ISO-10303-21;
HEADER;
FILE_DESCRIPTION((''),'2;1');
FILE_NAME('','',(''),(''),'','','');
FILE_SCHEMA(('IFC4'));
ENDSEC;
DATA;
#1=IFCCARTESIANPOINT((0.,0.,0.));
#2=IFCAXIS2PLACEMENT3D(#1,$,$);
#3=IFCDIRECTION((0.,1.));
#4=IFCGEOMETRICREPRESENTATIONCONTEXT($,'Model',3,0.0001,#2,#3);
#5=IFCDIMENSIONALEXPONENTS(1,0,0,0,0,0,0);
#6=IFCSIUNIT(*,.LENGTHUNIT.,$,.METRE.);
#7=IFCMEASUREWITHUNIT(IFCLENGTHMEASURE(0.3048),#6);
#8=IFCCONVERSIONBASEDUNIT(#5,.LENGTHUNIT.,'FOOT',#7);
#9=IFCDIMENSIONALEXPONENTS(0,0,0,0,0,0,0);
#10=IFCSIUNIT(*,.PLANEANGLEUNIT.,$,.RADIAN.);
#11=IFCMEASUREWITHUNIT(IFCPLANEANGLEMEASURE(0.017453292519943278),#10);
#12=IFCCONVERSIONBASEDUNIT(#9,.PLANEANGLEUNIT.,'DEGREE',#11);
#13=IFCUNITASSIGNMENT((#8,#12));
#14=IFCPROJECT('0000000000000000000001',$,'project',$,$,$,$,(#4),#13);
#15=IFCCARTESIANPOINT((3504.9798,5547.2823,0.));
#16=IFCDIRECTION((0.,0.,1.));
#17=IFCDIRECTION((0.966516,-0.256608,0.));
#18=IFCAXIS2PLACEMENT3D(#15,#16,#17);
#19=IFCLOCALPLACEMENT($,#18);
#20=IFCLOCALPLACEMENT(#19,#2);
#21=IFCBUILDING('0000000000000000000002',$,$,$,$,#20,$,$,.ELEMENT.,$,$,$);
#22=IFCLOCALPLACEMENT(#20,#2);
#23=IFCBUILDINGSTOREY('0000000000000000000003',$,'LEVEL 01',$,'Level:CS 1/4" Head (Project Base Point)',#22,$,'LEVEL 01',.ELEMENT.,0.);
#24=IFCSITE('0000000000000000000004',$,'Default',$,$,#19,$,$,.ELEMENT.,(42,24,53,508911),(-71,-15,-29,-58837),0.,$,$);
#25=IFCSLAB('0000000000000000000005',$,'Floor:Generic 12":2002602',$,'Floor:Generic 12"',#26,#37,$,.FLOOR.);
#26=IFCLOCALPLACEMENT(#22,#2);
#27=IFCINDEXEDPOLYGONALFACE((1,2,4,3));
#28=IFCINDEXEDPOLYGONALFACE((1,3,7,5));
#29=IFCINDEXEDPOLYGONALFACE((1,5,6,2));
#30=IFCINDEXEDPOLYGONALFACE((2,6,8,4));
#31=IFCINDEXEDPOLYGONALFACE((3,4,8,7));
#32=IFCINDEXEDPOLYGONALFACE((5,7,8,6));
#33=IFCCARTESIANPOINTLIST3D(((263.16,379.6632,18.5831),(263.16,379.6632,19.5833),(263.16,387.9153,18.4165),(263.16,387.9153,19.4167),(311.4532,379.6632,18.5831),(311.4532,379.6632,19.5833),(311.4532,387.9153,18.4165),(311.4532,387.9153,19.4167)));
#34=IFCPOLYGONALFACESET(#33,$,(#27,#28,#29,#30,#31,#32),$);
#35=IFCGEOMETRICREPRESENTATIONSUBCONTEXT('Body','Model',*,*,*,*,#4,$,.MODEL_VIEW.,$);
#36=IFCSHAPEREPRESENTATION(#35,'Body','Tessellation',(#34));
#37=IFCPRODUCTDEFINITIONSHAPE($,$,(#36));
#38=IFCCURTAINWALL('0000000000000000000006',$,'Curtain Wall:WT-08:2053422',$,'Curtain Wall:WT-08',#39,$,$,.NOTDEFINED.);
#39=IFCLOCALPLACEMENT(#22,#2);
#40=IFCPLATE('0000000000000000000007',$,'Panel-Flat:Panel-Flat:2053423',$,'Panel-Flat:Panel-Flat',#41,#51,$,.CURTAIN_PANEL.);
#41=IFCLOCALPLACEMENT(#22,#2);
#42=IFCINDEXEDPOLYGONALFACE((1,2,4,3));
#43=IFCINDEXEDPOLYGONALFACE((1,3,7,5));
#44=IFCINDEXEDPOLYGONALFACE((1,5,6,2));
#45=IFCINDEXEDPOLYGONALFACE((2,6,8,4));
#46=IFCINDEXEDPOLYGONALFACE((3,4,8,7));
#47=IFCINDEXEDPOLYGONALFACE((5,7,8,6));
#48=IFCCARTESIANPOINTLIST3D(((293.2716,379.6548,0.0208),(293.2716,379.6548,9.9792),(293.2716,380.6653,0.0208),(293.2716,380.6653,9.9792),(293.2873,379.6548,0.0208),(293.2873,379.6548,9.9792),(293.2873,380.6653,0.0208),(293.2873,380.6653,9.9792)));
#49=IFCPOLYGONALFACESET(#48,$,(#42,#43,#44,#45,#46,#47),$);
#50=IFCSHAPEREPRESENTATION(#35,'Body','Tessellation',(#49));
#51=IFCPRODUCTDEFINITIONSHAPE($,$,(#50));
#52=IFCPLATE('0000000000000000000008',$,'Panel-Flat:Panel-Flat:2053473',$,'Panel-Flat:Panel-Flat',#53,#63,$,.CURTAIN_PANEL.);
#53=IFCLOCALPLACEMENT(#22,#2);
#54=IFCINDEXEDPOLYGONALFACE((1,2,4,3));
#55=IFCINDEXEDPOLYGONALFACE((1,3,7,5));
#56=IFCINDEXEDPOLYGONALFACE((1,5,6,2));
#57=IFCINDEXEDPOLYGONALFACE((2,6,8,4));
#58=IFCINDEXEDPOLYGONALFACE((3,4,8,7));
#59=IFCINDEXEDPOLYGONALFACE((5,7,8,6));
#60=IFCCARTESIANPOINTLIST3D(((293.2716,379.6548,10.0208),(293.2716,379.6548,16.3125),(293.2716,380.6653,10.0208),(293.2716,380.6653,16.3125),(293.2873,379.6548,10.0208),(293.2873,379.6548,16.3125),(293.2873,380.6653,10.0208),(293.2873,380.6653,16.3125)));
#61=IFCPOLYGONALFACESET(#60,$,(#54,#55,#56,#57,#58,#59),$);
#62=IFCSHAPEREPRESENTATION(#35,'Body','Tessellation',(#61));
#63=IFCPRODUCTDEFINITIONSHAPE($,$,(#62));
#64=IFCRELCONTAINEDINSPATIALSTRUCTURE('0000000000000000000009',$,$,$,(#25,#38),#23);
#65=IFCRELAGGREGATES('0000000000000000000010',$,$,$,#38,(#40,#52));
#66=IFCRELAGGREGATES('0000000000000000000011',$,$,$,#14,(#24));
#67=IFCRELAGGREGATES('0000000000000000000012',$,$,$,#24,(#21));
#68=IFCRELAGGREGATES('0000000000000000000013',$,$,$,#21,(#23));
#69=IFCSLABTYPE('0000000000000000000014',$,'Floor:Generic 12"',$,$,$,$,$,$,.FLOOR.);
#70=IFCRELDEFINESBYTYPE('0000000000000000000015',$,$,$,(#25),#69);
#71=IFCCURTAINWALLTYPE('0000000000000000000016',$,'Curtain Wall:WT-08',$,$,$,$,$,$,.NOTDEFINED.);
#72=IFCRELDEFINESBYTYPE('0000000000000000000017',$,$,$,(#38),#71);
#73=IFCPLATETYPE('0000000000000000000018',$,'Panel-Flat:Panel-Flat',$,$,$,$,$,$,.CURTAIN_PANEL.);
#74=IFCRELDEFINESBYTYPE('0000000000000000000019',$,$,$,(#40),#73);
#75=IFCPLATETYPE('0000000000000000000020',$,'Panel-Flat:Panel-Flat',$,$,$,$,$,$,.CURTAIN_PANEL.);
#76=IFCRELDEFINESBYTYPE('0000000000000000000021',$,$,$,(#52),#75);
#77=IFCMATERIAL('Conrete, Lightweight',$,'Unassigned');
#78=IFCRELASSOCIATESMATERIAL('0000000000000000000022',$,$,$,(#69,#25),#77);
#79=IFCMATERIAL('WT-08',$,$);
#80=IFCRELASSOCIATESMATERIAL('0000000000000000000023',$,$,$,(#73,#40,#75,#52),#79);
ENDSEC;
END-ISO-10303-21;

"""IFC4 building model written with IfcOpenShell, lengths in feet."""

from ifc_helpers import new_model, entity, si_unit, converted_unit, direction, frame, frame_2d, origin, place, context, subcontext, project, spatial, indexed_curve, rectangle, outline, extrude, source, transform, mapped, material, type_object, type_shapes, element, aggregate, save


model = new_model("IFC4")

# Units and contexts
model_context = context("Model", 3, precision=0.0001, world=origin(), true_north=direction((0.0, 1.0)))
body_context = subcontext(model_context, "Body", "Model", "MODEL_VIEW")
ifc_project = project(units=[converted_unit("LENGTHUNIT", "FOOT", entity("IfcLengthMeasure", 0.3048), si_unit("LENGTHUNIT", "METRE"), dimensions=[1, 0, 0, 0, 0, 0, 0]), converted_unit("PLANEANGLEUNIT", "DEGREE", entity("IfcPlaneAngleMeasure", 0.017453292519943278), si_unit("PLANEANGLEUNIT", "RADIAN"), dimensions=[0, 0, 0, 0, 0, 0, 0])], contexts=[model_context])

# Site, building, storey
site_placement = place(None, frame((3504.9798, 5547.2823, 0.0), z_axis=(0.0, 0.0, 1.0), x_axis=(0.966516, -0.256608, 0.0)))
site = spatial("IfcSite", under=ifc_project, at=site_placement, Name="Default", CompositionType="ELEMENT", RefLatitude=(42, 24, 53, 508911), RefLongitude=(-71, -15, -29, -58837), RefElevation=0.0)
building_placement = place(site_placement, origin())
building = spatial("IfcBuilding", under=site, at=building_placement, CompositionType="ELEMENT")
storey_placement = place(building_placement, origin())
storey = spatial("IfcBuildingStorey", under=building, at=storey_placement, Name="LEVEL 01", ObjectType="Level:CS 1/4\" Head (Project Base Point)", LongName="LEVEL 01", CompositionType="ELEMENT", Elevation=0.0)

# Shared definitions
curtain_wall_type_1 = type_object("IfcCurtainWallType", Name="Curtain Wall:WT-08", PredefinedType="NOTDEFINED")
ifc_material_1 = material(Name="WT-08")

# Slab
ifc_material_2 = material(Name="Conrete, Lightweight", Category="Unassigned")
slab_type = type_object("IfcSlabType", Name="Floor:Generic 12\"", PredefinedType="FLOOR", material=ifc_material_2)
slab_placement = place(storey_placement, frame((263.16, 379.6632, 18.4165)))
element("IfcSlab", 1, at=slab_placement, inside=storey, type_object=slab_type, material=ifc_material_2, Name="Floor:Generic 12\":2002602", ObjectType="Floor:Generic 12\"", PredefinedType="FLOOR", context=body_context, shape_type="SweptSolid", body=[
    extrude(rectangle(XDim=48.2932, YDim=8.2537, at=frame_2d((0.0, 4.1269), x_axis=(-1.0, 0.0))), frame((24.1466, 0.0, 1.1669), z_axis=(0.0, 0.020193, 0.999796), x_axis=(1.0, 0.0, 0.0)), (0.0, 0.020193, -0.999796), 1.0002),
])

# Curtain wall, plates
curtain_wall_1_placement = place(storey_placement, origin())
curtain_wall_1 = element("IfcCurtainWall", 2, at=curtain_wall_1_placement, inside=storey, type_object=curtain_wall_type_1, Name="Curtain Wall:WT-08:2053422", ObjectType="Curtain Wall:WT-08", PredefinedType="NOTDEFINED")
plate_type_1 = type_object("IfcPlateType", Name="Panel-Flat:Panel-Flat", PredefinedType="CURTAIN_PANEL", material=ifc_material_1)
shared_shape_1 = source(origin(), body_context, "Body", "SweptSolid", [
    extrude(outline(indexed_curve([(-0.0078, -0.5052), (0.0078, -0.5052), (0.0078, 0.5052), (-0.0078, 0.5052), (-0.0078, -0.5052)], self_intersect=False)), frame((0.0, -0.0078, 0.0208), z_axis=(0.0, 0.0, 1.0), x_axis=(0.0, -1.0, 0.0)), (0.0, 0.0, 1.0), 9.9583),
])
type_shapes(plate_type_1, [shared_shape_1])
plate_1_placement = place(curtain_wall_1_placement, frame((293.2873, 380.1601, 0.0), z_axis=(0.0, 0.0, 1.0), x_axis=(0.0, -1.0, 0.0)))
plate_1 = element("IfcPlate", 3, at=plate_1_placement, type_object=plate_type_1, material=ifc_material_1, Name="Panel-Flat:Panel-Flat:2053423", ObjectType="Panel-Flat:Panel-Flat", PredefinedType="CURTAIN_PANEL", context=body_context, shape_type="MappedRepresentation", body=[
    mapped(shared_shape_1, transform((0.0, 0.0, 0.0), scale=1.0)),
])
plate_type_2 = type_object("IfcPlateType", Name="Panel-Flat:Panel-Flat", PredefinedType="CURTAIN_PANEL", material=ifc_material_1)
shared_shape_2 = source(origin(), body_context, "Body", "SweptSolid", [
    extrude(outline(indexed_curve([(-0.0078, -0.5052), (0.0078, -0.5052), (0.0078, 0.5052), (-0.0078, 0.5052), (-0.0078, -0.5052)], self_intersect=False)), frame((0.0, -0.0078, 0.0208), z_axis=(0.0, 0.0, 1.0), x_axis=(0.0, -1.0, 0.0)), (0.0, 0.0, 1.0), 6.2917),
])
type_shapes(plate_type_2, [shared_shape_2])
plate_2_placement = place(curtain_wall_1_placement, frame((293.2873, 380.1601, 10.0), z_axis=(0.0, 0.0, 1.0), x_axis=(0.0, -1.0, 0.0)))
plate_2 = element("IfcPlate", 4, at=plate_2_placement, type_object=plate_type_2, material=ifc_material_1, Name="Panel-Flat:Panel-Flat:2053473", ObjectType="Panel-Flat:Panel-Flat", PredefinedType="CURTAIN_PANEL", context=body_context, shape_type="MappedRepresentation", body=[
    mapped(shared_shape_2, transform((0.0, 0.0, 0.0), scale=1.0)),
])
aggregate(curtain_wall_1, [plate_1, plate_2])

save(model, "model.ifc")
